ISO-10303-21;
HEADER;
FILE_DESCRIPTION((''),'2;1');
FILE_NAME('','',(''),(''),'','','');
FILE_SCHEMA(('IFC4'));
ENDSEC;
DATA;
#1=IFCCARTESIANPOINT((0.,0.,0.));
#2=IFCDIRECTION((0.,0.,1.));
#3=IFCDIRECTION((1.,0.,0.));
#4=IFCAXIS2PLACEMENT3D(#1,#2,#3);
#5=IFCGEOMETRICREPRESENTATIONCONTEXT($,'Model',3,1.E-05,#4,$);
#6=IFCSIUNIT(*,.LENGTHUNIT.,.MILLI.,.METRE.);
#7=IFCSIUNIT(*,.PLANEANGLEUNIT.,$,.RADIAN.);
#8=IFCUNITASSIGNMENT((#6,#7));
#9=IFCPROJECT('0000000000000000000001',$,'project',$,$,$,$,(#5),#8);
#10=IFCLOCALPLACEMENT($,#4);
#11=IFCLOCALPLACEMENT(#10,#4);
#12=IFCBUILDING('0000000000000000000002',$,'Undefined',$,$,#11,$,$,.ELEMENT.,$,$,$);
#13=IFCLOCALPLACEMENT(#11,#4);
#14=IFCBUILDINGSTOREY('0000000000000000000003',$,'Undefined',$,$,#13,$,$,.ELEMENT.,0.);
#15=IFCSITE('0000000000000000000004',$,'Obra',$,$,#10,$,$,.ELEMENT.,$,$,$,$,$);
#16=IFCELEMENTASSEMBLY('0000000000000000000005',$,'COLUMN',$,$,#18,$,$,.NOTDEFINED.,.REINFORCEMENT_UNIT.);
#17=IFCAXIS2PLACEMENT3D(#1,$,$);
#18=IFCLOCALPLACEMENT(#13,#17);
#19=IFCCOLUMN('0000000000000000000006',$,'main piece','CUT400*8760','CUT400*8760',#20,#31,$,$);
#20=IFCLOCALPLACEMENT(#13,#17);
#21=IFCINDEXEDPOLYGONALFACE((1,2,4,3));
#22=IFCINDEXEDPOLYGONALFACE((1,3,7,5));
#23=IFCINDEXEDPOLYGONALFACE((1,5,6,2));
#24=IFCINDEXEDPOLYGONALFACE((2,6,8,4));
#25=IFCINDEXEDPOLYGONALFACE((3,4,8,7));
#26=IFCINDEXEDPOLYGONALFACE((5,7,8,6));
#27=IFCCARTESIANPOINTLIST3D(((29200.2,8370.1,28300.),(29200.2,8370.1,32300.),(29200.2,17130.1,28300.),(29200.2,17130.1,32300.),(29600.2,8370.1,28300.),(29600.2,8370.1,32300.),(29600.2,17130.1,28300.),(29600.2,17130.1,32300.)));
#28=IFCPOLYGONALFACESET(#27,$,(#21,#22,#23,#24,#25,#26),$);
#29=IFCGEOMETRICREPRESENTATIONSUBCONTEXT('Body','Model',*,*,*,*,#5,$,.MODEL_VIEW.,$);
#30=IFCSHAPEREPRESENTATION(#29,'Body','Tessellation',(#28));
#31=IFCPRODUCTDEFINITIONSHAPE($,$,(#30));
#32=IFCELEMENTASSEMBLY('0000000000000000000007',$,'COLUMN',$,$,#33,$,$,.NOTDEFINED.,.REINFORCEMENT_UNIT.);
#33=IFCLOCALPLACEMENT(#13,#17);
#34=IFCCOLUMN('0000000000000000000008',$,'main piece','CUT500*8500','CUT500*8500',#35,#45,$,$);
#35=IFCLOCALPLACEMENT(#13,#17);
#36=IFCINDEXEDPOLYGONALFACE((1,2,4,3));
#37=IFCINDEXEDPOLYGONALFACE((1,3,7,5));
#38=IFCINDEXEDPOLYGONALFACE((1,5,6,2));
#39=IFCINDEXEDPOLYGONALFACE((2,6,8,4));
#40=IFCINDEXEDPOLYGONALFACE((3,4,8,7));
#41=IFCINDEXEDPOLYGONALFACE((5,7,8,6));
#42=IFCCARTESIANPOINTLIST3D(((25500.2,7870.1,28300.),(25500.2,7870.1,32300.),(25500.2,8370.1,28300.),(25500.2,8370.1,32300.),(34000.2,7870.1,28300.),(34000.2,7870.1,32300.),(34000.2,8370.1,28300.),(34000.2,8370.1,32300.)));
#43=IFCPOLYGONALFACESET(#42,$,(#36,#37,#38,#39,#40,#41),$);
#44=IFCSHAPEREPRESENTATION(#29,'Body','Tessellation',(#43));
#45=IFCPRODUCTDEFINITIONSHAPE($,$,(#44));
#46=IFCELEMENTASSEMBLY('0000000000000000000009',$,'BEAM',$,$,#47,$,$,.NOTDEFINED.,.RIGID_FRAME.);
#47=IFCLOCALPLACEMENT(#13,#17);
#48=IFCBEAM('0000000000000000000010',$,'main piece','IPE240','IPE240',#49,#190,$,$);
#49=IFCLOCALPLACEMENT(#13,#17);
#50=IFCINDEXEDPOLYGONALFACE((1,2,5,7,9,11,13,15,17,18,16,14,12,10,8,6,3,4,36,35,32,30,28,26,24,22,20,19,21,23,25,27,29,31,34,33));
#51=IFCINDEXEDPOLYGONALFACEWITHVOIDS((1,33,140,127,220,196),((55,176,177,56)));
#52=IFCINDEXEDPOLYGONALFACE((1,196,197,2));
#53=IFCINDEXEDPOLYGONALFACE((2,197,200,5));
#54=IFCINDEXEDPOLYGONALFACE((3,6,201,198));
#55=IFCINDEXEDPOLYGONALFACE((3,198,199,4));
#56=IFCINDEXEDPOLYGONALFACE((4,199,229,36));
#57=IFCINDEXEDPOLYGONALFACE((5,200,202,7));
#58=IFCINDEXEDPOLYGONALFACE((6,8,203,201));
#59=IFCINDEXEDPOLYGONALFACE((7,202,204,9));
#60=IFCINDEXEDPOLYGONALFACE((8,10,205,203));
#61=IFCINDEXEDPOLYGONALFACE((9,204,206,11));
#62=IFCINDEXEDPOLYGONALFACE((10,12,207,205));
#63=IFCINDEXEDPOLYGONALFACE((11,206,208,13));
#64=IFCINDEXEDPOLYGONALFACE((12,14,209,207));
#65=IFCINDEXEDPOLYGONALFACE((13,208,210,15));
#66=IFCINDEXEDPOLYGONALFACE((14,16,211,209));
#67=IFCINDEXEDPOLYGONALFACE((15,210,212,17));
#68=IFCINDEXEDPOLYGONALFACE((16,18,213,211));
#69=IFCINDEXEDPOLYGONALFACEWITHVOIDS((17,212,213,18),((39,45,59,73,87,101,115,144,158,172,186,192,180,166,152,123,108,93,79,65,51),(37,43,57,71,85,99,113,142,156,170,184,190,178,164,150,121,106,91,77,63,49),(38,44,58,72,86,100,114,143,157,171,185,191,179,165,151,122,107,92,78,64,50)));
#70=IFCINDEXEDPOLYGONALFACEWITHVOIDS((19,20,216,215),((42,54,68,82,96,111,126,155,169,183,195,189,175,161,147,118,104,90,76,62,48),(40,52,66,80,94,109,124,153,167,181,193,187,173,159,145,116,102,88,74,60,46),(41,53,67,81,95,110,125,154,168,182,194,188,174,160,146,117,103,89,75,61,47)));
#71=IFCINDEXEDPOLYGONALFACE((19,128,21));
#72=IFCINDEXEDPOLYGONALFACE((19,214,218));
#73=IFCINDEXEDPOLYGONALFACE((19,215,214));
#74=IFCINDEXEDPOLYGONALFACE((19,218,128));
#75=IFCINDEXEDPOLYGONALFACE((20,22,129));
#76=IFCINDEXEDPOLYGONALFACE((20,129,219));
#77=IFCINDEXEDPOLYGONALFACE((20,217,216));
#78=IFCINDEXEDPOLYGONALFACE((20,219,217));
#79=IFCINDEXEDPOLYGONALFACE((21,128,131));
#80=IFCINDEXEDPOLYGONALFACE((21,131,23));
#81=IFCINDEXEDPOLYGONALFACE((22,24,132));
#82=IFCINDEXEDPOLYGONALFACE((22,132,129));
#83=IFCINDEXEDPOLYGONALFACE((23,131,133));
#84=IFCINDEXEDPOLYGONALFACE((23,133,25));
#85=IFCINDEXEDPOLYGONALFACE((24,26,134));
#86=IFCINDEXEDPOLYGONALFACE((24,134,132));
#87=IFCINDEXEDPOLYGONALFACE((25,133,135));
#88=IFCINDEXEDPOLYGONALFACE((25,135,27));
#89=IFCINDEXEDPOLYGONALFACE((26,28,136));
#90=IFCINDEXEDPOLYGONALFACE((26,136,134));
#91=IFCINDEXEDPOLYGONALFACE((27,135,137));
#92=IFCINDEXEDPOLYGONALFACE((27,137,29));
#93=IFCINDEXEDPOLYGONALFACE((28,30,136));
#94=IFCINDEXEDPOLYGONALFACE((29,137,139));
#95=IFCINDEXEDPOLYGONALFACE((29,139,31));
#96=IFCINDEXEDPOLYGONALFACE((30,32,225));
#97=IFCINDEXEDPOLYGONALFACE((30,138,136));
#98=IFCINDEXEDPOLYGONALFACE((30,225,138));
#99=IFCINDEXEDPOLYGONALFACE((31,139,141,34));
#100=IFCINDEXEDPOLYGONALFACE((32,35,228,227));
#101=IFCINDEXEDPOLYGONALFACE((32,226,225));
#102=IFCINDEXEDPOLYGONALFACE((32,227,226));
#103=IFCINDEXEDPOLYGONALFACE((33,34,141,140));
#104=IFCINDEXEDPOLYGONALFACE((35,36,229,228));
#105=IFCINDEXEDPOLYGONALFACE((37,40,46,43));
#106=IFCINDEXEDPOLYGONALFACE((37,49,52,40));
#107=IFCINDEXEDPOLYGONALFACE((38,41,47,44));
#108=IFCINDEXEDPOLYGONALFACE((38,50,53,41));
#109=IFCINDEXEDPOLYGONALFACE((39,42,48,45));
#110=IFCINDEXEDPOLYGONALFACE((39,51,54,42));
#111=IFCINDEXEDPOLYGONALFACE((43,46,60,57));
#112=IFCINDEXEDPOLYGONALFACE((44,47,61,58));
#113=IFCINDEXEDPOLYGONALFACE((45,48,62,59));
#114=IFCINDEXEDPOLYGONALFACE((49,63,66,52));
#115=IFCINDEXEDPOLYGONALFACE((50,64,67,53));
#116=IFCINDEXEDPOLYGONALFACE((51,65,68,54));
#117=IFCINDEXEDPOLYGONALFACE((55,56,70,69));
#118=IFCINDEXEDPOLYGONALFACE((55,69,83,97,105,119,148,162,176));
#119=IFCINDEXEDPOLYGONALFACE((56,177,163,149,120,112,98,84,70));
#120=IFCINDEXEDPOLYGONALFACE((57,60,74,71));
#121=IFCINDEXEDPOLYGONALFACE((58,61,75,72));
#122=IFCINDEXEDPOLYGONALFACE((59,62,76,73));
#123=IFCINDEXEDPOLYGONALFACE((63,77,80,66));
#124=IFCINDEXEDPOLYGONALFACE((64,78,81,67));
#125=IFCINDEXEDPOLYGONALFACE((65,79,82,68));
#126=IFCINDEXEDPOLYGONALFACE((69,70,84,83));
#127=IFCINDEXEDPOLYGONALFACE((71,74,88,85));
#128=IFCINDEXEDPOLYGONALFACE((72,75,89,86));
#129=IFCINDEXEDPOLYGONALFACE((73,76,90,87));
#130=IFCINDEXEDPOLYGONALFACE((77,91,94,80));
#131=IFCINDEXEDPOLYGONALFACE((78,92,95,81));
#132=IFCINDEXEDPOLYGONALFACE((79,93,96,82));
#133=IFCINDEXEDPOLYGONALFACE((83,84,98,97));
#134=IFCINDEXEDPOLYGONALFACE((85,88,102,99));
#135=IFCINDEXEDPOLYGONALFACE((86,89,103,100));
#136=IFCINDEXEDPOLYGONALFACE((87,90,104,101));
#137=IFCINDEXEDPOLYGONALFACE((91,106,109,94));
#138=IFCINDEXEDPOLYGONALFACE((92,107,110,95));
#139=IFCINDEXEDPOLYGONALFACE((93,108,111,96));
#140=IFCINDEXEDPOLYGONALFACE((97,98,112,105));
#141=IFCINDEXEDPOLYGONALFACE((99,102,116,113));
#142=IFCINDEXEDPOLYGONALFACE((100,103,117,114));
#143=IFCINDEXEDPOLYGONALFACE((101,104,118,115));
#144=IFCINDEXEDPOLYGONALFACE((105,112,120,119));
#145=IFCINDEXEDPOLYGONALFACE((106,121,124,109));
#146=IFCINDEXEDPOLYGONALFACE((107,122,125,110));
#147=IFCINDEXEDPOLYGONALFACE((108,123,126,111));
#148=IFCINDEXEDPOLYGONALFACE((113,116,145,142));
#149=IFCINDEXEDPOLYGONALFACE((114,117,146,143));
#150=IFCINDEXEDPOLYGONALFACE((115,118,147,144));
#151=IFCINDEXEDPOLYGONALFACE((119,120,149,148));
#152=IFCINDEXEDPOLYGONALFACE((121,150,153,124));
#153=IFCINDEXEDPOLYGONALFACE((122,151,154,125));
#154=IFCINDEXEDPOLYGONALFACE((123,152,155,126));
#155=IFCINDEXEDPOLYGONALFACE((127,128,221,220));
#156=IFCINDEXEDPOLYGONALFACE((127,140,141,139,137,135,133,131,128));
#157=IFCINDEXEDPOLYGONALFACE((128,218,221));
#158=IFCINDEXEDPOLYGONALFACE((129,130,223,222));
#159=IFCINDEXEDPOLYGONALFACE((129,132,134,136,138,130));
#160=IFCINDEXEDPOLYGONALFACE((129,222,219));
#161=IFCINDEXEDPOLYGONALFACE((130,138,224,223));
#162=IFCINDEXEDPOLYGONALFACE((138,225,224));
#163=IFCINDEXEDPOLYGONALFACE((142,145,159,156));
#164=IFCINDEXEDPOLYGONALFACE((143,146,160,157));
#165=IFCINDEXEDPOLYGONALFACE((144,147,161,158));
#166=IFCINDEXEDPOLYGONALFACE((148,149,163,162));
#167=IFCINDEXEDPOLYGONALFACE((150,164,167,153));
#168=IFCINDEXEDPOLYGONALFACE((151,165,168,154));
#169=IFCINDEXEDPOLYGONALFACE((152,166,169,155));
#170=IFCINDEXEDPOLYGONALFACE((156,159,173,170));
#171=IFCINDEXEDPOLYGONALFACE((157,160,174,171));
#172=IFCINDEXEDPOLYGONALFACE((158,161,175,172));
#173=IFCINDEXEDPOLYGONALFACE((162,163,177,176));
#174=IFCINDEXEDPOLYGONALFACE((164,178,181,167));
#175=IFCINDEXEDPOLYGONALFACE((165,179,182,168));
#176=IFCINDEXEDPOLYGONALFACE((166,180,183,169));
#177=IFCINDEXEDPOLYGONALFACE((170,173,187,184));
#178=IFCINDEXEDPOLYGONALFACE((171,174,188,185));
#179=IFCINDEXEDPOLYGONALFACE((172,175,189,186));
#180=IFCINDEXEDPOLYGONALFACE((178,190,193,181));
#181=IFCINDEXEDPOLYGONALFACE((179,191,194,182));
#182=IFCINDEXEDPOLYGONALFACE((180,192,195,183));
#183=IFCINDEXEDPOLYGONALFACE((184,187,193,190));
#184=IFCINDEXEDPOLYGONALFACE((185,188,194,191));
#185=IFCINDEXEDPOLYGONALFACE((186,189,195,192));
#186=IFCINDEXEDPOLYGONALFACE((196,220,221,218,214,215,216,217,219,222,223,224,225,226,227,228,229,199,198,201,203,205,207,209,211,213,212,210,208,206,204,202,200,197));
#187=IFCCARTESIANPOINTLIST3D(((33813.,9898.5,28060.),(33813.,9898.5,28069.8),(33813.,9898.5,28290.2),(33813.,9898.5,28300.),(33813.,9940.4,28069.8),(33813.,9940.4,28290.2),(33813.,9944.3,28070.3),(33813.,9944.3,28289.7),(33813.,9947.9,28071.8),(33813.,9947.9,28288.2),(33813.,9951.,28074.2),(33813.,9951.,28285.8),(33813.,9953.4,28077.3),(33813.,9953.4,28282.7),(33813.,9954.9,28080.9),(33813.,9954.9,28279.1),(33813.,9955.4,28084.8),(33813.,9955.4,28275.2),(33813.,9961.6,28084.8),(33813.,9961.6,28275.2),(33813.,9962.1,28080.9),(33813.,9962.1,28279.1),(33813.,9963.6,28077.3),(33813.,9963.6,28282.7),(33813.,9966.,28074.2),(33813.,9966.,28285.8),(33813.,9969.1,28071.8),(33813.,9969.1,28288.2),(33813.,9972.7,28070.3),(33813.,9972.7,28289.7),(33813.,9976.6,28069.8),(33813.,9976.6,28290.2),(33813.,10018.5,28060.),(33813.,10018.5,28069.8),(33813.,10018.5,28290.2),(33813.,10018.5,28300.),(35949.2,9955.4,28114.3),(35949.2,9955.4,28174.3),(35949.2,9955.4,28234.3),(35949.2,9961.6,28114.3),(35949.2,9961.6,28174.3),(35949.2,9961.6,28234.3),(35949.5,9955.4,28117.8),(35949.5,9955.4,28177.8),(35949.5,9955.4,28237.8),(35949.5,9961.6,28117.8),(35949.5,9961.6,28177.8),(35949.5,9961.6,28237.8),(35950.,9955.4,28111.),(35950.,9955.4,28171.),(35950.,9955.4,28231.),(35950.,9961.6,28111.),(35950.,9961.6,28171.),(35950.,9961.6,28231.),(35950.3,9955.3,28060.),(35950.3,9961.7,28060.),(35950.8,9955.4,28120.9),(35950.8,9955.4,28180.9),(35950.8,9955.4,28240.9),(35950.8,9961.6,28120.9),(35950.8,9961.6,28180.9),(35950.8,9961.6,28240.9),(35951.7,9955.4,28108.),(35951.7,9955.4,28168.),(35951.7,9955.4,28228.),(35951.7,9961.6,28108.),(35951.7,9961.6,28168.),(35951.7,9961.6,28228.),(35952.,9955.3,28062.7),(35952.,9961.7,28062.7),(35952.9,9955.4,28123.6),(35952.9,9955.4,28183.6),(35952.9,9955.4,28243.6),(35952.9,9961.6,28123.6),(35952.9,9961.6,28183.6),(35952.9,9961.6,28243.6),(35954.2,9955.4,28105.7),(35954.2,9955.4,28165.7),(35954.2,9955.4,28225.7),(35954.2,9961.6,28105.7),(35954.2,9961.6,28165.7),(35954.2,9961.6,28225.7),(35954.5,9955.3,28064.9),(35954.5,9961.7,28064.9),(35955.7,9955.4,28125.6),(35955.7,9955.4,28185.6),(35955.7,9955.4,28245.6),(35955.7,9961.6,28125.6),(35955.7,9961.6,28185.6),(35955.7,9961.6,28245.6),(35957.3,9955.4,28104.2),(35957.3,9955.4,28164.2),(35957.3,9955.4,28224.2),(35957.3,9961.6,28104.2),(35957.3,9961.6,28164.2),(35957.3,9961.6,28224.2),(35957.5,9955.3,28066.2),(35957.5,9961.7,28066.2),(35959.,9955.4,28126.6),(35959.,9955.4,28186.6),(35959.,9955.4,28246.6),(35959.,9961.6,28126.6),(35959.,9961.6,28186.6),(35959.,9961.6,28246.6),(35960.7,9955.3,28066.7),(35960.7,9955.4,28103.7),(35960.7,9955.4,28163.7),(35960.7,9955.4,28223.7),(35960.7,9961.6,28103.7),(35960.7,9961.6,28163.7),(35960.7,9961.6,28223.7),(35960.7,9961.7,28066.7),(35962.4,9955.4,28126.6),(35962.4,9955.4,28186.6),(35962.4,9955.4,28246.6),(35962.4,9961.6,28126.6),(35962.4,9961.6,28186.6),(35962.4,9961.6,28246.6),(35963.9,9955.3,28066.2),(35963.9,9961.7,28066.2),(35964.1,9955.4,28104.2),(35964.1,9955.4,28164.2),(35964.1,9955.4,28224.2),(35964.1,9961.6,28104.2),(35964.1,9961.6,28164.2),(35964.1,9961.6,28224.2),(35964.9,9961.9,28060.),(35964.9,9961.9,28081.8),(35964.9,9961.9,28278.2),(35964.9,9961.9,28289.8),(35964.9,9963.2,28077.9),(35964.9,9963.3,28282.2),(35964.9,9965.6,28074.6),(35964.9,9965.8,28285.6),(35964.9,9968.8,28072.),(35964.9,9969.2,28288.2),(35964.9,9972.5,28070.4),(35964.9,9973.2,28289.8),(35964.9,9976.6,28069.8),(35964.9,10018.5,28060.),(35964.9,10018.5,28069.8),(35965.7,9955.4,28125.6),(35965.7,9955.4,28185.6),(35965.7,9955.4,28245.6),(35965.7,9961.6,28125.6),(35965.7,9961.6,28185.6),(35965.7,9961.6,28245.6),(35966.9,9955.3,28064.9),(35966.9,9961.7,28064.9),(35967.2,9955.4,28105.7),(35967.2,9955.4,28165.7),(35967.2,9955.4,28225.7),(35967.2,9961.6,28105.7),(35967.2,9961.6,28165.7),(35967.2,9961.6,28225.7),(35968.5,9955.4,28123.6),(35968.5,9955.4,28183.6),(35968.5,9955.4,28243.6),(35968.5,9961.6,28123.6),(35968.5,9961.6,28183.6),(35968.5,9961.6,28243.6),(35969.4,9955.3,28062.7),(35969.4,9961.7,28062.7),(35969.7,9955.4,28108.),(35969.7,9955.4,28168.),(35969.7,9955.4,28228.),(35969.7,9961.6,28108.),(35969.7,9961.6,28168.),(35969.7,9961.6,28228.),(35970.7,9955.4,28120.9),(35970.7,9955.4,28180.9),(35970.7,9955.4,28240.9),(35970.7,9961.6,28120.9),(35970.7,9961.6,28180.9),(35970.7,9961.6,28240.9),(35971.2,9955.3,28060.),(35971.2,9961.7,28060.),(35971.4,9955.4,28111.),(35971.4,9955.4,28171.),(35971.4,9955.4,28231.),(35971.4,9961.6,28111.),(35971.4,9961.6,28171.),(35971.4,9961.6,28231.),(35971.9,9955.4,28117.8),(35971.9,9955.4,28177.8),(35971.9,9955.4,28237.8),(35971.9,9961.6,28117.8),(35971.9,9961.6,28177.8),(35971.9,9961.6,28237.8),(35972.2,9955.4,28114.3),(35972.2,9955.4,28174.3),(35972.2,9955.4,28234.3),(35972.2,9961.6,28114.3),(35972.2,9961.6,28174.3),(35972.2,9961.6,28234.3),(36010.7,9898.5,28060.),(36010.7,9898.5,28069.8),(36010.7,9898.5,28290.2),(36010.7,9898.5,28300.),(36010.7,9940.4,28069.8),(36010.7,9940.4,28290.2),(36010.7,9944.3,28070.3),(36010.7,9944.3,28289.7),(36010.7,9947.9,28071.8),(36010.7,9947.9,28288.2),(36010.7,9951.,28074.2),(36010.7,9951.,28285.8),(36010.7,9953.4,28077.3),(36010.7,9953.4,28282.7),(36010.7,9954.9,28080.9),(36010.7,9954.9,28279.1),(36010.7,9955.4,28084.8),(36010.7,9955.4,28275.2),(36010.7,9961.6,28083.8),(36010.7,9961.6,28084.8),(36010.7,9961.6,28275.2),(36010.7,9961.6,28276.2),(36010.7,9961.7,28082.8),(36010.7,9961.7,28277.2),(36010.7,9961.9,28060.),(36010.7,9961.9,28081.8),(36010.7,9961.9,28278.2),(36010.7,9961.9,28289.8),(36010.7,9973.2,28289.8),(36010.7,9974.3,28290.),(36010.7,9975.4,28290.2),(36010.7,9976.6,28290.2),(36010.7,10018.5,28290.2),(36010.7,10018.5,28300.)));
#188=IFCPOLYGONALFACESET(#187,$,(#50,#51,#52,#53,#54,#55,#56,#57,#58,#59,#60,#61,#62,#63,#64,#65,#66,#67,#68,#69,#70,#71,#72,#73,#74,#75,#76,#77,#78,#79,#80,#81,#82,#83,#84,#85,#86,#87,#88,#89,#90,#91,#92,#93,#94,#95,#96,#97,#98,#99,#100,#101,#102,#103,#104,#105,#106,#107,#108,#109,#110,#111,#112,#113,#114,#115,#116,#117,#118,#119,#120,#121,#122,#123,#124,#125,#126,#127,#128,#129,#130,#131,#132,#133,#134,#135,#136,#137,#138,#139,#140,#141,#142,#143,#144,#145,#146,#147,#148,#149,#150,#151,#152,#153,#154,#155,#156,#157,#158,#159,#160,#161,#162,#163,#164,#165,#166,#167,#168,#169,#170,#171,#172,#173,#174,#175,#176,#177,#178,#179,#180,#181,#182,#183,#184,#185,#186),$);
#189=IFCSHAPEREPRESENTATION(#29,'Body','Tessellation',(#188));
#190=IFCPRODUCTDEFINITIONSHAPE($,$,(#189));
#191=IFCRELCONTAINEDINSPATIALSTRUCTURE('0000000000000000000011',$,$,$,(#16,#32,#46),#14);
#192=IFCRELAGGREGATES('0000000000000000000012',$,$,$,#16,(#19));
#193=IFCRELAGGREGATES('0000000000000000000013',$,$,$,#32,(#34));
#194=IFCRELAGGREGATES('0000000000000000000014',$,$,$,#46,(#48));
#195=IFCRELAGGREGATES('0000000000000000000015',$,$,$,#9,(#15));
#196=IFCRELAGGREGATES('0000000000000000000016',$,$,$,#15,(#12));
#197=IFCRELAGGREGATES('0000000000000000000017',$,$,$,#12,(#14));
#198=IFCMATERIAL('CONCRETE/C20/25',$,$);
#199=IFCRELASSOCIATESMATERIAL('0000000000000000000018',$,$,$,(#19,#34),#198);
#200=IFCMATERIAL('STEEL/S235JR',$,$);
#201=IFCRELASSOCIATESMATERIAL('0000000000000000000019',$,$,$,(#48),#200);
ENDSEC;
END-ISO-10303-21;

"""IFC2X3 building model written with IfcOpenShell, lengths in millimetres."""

from ifc_helpers import new_model, si_unit, frame, origin_with_axes, origin_2d_with_axis, place, context, subcontext, project, spatial, rectangle, circle, i_section, extrude, clip, halfspace, source, transform, mapped, material, element, aggregate, save


model = new_model("IFC2X3")

# Units and contexts
model_context = context("Model", 3, precision=1e-05, world=origin_with_axes())
body_context = subcontext(model_context, "Body", "Model", "MODEL_VIEW")
ifc_project = project(units=[si_unit("LENGTHUNIT", "METRE", prefix="MILLI"), si_unit("PLANEANGLEUNIT", "RADIAN")], contexts=[model_context])

# Site, building, storey
site_placement = place(None, origin_with_axes())
site = spatial("IfcSite", under=ifc_project, at=site_placement, Name="Obra", CompositionType="ELEMENT")
building_placement = place(site_placement, origin_with_axes())
building = spatial("IfcBuilding", under=site, at=building_placement, Name="Undefined", CompositionType="ELEMENT")
storey_placement = place(building_placement, origin_with_axes())
storey = spatial("IfcBuildingStorey", under=building, at=storey_placement, Name="Undefined", CompositionType="ELEMENT", Elevation=0.0)

# Element assemblies, columns
assembly_1_placement = place(storey_placement, origin_with_axes())
assembly_1 = element("IfcElementAssembly", 1, at=assembly_1_placement, inside=storey, Name="COLUMN", AssemblyPlace="NOTDEFINED", PredefinedType="REINFORCEMENT_UNIT")
ifc_material_1 = material(Name="CONCRETE/C20/25")
column_1_placement = place(assembly_1_placement, frame((29400.2, 12750.1, 28300.0), z_axis=(0.0, 0.0, 1.0), x_axis=(0.0, -1.0, 0.0)))
column_1 = element("IfcColumn", 2, at=column_1_placement, material=ifc_material_1, Name="main piece", Description="CUT400*8760", ObjectType="CUT400*8760", context=body_context, shape_type="SweptSolid", body=[
    extrude(rectangle(XDim=400.0, YDim=8760.0, at=origin_2d_with_axis()), frame((0.0, 0.0, 4000.0), z_axis=(0.0, 0.0, -1.0), x_axis=(0.0, 1.0, 0.0)), (0.0, 0.0, 1.0), 4000.0),
])
aggregate(assembly_1, [column_1])
assembly_2_placement = place(storey_placement, origin_with_axes())
assembly_2 = element("IfcElementAssembly", 3, at=assembly_2_placement, inside=storey, Name="COLUMN", AssemblyPlace="NOTDEFINED", PredefinedType="REINFORCEMENT_UNIT")
column_2_placement = place(assembly_2_placement, frame((29750.2, 8120.1, 28300.0), z_axis=(0.0, 0.0, 1.0), x_axis=(-1.0, 0.0, 0.0)))
column_2 = element("IfcColumn", 4, at=column_2_placement, material=ifc_material_1, Name="main piece", Description="CUT500*8500", ObjectType="CUT500*8500", context=body_context, shape_type="SweptSolid", body=[
    extrude(rectangle(XDim=500.0, YDim=8500.0, at=origin_2d_with_axis()), frame((0.0, 0.0, 4000.0), z_axis=(0.0, 0.0, -1.0), x_axis=(0.0, 1.0, 0.0)), (0.0, 0.0, 1.0), 4000.0),
])
aggregate(assembly_2, [column_2])

# Element assembly, beam, openings
ifc_material_2 = material(Name="STEEL/S235JR")
assembly_3_placement = place(storey_placement, origin_with_axes())
assembly_3 = element("IfcElementAssembly", 5, at=assembly_3_placement, inside=storey, Name="BEAM", AssemblyPlace="NOTDEFINED", PredefinedType="RIGID_FRAME")
beam_1_placement = place(assembly_3_placement, frame((33813.0, 9958.5, 28180.0), z_axis=(0.0, 0.0, 1.0), x_axis=(1.0, 0.0, 0.0)))
beam_1 = element("IfcBeam", 6, at=beam_1_placement, material=ifc_material_2, Name="main piece", Description="IPE240", ObjectType="IPE240", context=body_context, shape_type="Clipping", body=[
    clip(extrude(i_section(OverallWidth=120.0, OverallDepth=240.0, WebThickness=6.2, FlangeThickness=9.8, FilletRadius=15.0, at=origin_2d_with_axis()), frame((2197.7, 0.0, 0.0), z_axis=(-1.0, 0.0, 0.0), x_axis=(0.0, -1.0, 0.0)), (0.0, 0.0, 1.0), 2197.7), halfspace(frame((2197.7, 0.0, -220.0), z_axis=(-1.0, 0.0, 0.0), x_axis=(0.0, 1.0, 0.0)), True)),
])
opening_1_placement = place(assembly_3_placement, frame((33813.0, 9958.5, 28180.0), z_axis=(0.0, 0.0, 1.0), x_axis=(1.0, 0.0, 0.0)))
element("IfcOpeningElement", 7, at=opening_1_placement, cuts=beam_1, ObjectType="Recess", context=body_context, shape_type="SweptSolid", body=[
    extrude(rectangle(XDim=26.2, YDim=76.2, at=origin_2d_with_axis()), frame((2235.8, 61.0, 107.9), z_axis=(0.0, -1.0, 0.0), x_axis=(0.0, 0.0, -1.0)), (0.0, 0.0, 1.0), 122.0),
])
opening_2_placement = place(assembly_3_placement, frame((33813.0, 9958.5, 28180.0), z_axis=(0.0, 0.0, 1.0), x_axis=(1.0, 0.0, 0.0)))
element("IfcOpeningElement", 8, at=opening_2_placement, cuts=beam_1, ObjectType="Recess", context=body_context, shape_type="SweptSolid", body=[
    extrude(rectangle(XDim=120.0, YDim=174.2, at=origin_2d_with_axis()), frame((2211.9, 90.5, 109.8), z_axis=(0.0, 0.0, -1.0), x_axis=(-1.0, 0.0, 0.0)), (0.0, 0.0, 1.0), 249.6),
])
shared_shape_1 = source(origin_with_axes(), body_context, "Body", "SweptSolid", [
    extrude(circle(Radius=11.5, at=origin_2d_with_axis()), frame((0.0, -3.2, 0.0), z_axis=(0.0, 1.0, 0.0), x_axis=(1.0, 0.0, 0.0)), (0.0, 0.0, 1.0), 6.4),
])
opening_3_placement = place(assembly_3_placement, frame((36010.7, 9958.5, 28275.2), z_axis=(-1.0, 0.0, 0.0), x_axis=(0.0, 0.0, -1.0)))
element("IfcOpeningElement", 9, at=opening_3_placement, cuts=beam_1, ObjectType="Opening", context=body_context, shape_type="MappedRepresentation", body=[
    mapped(shared_shape_1, transform((40.0, 0.0, 50.0))),
    mapped(shared_shape_1, transform((100.0, 0.0, 50.0))),
    mapped(shared_shape_1, transform((160.0, 0.0, 50.0))),
    mapped(shared_shape_1, transform((220.0, 0.0, 50.0))),
])

aggregate(assembly_3, [beam_1])

save(model, "model.ifc")
